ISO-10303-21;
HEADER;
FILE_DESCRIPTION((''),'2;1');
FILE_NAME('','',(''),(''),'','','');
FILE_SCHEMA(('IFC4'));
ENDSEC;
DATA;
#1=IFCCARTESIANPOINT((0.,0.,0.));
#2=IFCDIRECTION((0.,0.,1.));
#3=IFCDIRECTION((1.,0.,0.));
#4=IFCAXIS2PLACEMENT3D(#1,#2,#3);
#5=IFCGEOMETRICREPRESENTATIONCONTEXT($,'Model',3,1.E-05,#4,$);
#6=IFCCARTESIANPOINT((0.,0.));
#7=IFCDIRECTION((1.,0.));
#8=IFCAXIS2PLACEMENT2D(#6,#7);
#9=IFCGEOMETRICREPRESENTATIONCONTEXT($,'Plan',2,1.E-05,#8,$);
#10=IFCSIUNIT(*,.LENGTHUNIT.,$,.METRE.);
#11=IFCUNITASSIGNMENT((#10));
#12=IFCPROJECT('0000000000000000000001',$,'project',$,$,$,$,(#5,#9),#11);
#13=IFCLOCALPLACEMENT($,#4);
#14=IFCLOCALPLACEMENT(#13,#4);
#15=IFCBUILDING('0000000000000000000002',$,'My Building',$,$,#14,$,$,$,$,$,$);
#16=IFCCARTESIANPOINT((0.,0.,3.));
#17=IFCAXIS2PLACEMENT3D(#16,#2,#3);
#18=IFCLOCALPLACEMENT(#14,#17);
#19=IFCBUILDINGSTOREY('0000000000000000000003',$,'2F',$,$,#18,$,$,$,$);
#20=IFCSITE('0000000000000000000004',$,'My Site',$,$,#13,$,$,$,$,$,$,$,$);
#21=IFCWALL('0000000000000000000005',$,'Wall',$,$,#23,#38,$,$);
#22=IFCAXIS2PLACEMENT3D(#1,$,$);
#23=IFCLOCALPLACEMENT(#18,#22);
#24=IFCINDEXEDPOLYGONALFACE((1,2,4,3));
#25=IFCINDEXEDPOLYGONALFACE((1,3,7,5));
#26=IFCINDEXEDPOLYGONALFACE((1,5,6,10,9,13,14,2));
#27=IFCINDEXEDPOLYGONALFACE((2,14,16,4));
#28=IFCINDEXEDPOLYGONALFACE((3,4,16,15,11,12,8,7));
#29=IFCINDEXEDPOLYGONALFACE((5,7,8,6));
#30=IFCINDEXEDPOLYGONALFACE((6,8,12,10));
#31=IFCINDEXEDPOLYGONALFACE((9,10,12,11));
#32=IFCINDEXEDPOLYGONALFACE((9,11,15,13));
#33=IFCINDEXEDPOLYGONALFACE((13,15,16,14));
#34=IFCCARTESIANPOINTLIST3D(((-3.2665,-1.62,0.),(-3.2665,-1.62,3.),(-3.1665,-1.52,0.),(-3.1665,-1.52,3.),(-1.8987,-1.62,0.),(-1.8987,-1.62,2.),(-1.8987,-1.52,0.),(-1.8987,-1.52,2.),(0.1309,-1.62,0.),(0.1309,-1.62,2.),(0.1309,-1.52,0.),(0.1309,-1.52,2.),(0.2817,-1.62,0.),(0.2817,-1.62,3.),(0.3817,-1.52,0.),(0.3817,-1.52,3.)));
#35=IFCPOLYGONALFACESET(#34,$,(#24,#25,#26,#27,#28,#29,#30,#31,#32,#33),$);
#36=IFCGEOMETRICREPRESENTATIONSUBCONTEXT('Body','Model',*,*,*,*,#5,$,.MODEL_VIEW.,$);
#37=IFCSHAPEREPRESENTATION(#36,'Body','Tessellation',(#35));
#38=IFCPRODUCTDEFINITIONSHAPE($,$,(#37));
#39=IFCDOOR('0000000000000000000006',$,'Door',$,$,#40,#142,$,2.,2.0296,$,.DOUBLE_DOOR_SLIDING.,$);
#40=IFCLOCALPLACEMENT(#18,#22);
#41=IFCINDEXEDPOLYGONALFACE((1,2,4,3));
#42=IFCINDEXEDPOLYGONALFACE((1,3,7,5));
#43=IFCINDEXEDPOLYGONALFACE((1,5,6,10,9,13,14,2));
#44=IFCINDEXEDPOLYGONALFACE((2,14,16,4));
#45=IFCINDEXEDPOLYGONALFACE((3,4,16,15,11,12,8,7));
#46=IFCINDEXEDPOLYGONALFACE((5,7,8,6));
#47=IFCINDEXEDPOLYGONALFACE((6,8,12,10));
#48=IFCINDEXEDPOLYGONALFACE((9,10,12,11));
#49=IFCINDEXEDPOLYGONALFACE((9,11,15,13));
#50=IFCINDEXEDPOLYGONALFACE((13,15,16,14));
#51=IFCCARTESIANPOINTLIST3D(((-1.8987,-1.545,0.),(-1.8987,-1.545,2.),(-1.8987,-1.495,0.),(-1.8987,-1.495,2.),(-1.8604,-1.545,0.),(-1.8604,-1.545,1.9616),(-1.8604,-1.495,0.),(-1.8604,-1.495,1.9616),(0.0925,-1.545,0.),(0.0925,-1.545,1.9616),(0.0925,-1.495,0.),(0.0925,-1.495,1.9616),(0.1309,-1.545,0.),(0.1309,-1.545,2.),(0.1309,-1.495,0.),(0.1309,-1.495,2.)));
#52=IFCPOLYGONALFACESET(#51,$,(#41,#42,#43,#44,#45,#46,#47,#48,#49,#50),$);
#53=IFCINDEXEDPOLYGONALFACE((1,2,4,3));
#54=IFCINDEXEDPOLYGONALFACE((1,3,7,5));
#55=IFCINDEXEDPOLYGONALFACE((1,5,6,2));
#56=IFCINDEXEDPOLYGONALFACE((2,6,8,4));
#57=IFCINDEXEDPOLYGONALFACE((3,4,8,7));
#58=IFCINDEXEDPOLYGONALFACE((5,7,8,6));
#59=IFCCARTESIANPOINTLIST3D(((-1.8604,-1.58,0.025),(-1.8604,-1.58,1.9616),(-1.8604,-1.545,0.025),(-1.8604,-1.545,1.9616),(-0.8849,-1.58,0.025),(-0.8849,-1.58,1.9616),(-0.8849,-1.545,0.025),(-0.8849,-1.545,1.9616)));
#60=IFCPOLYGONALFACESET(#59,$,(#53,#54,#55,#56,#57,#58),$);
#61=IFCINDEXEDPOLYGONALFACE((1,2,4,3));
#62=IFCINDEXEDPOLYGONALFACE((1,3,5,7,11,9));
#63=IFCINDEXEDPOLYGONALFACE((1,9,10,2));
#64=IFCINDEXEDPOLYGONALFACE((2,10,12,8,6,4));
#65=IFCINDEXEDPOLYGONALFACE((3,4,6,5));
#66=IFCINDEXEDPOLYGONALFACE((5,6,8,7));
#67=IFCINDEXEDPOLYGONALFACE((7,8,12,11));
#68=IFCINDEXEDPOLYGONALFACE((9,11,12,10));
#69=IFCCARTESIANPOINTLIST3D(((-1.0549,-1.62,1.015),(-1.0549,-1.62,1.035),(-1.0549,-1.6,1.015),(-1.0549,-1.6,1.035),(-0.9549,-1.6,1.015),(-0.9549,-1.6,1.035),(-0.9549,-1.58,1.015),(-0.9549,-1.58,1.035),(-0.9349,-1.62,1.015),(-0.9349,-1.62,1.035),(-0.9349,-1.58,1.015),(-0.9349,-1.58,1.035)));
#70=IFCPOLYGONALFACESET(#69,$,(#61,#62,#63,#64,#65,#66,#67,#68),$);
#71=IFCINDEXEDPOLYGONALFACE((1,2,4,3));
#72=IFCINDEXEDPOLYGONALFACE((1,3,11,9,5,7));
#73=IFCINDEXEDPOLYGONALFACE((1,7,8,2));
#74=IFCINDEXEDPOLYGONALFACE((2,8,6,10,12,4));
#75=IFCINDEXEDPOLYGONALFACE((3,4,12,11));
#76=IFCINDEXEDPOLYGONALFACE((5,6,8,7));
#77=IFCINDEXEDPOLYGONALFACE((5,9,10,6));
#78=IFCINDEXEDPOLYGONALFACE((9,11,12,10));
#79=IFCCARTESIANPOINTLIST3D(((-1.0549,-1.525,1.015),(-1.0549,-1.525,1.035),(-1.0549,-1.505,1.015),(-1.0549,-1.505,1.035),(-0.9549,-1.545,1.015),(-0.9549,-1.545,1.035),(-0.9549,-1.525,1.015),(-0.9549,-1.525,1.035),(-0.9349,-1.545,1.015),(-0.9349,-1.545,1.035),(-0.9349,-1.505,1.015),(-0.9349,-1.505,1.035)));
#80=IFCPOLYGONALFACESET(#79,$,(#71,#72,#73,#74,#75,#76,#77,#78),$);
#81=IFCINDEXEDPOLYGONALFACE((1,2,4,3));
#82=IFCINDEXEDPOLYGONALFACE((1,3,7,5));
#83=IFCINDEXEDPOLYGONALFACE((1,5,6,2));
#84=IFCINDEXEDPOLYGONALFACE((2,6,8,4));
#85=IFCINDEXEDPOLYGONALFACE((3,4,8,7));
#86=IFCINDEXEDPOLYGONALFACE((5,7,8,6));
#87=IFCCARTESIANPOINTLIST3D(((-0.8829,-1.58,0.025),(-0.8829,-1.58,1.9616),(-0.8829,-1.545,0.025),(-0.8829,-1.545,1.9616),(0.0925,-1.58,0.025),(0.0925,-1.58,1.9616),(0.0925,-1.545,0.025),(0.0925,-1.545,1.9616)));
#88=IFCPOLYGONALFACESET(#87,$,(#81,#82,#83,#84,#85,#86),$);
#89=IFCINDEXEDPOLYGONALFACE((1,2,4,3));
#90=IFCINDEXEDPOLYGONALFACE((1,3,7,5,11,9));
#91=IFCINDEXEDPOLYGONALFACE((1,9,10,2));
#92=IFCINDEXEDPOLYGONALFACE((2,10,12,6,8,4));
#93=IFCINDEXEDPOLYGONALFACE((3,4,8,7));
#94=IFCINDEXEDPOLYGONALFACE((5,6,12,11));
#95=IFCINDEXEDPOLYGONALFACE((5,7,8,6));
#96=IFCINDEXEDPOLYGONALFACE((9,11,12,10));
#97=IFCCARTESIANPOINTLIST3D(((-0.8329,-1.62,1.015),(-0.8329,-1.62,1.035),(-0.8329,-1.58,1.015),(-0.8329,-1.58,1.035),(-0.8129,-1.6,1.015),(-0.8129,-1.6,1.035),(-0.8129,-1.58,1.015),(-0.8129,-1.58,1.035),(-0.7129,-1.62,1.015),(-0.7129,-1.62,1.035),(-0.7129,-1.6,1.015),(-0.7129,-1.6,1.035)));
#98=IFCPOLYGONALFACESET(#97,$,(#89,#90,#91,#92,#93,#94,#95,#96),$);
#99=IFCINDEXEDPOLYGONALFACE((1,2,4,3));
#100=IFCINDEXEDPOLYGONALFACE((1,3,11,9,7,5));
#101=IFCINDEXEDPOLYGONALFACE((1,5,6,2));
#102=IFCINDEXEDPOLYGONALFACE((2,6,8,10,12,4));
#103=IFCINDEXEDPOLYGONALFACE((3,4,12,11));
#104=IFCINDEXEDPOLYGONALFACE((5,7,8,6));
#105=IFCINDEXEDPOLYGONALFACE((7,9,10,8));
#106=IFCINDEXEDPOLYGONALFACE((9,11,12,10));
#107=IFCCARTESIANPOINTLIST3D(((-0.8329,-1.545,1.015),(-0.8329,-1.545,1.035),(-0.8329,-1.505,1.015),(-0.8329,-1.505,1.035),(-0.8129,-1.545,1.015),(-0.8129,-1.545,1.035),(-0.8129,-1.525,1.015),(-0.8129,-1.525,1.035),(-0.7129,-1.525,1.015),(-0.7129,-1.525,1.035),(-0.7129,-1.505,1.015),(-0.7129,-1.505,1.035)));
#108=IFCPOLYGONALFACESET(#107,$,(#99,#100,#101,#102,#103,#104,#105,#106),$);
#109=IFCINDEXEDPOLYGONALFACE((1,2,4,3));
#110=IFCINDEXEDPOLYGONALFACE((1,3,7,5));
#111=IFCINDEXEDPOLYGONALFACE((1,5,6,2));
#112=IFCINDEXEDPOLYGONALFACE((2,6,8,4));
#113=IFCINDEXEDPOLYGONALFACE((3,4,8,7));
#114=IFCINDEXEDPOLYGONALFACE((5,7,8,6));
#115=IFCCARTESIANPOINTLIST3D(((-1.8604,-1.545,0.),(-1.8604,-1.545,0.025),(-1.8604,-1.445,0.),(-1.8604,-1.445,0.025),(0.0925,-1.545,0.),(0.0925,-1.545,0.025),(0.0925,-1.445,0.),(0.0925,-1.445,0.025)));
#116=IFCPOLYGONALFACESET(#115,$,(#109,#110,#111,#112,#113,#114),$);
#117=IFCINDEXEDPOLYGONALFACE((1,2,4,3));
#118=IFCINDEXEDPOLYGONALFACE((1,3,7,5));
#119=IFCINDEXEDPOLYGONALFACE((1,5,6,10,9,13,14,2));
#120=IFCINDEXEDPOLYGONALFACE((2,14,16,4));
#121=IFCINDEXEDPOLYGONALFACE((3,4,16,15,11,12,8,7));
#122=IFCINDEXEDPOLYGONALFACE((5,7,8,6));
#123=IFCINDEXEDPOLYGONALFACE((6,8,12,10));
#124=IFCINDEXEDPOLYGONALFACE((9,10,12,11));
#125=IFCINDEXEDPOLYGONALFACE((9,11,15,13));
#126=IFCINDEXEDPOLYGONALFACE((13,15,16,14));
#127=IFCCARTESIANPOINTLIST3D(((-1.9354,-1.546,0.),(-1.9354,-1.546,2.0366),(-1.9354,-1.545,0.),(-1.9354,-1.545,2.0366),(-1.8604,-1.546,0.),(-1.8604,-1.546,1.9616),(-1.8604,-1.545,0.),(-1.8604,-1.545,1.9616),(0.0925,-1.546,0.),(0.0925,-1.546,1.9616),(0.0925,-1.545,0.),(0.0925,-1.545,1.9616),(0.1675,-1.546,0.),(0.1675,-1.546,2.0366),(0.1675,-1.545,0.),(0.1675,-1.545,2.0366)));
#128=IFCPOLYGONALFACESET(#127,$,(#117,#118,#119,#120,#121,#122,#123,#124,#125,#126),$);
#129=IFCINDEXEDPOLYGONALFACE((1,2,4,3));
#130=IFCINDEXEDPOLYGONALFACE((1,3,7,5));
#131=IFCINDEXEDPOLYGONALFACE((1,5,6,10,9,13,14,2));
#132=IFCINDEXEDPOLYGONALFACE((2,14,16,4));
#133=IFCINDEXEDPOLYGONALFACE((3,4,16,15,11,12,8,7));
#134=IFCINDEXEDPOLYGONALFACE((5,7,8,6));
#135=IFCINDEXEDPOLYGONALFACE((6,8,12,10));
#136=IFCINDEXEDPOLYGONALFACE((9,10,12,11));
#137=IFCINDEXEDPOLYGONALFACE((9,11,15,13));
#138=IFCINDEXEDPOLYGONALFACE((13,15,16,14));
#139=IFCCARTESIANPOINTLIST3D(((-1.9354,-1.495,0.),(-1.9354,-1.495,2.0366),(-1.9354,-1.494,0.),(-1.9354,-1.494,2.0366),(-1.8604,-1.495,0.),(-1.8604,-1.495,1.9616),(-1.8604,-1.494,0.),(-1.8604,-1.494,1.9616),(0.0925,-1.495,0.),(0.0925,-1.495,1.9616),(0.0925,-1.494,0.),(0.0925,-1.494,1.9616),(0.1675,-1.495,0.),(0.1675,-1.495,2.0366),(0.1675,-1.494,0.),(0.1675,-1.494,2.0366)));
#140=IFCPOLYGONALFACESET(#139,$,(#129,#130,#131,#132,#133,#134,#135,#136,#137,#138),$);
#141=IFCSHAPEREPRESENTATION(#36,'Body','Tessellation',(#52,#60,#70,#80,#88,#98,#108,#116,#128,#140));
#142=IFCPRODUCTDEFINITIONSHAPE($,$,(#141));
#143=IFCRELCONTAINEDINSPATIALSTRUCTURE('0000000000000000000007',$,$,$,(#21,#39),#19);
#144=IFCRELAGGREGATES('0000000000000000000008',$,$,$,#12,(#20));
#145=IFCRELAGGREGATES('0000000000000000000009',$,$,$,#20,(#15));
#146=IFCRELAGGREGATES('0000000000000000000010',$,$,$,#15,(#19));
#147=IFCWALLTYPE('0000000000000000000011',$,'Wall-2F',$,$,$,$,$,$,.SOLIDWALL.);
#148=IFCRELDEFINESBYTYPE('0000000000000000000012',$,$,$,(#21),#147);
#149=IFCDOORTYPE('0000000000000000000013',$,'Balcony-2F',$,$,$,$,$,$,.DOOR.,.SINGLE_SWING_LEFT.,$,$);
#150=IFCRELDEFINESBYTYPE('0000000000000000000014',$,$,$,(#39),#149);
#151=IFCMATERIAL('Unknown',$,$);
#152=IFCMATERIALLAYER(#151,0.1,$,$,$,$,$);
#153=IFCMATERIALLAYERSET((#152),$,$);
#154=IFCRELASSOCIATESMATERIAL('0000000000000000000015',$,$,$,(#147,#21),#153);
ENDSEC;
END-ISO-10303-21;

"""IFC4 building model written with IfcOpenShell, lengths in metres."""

from ifc_helpers import new_model, entity, si_unit, frame, origin_with_axes, origin_2d_with_axis, place, context, subcontext, project, spatial, line, indexed_curve, outline, extrude, shape, source, transform, mapped, material, layer, layer_set, layer_usage, type_object, type_shapes, element, fill, save


model = new_model("IFC4")

# Units and contexts
model_context = context("Model", 3, precision=1e-05, world=origin_with_axes())
plan_context = context("Plan", 2, precision=1e-05, world=origin_2d_with_axis())
body_context_1 = subcontext(model_context, "Body", "Model", "MODEL_VIEW")
body_context_2 = subcontext(plan_context, "Body", "Plan", "PLAN_VIEW")
ifc_project = project(units=[si_unit("LENGTHUNIT", "METRE")], contexts=[model_context, plan_context])

# Site, building, storey
site_placement = place(None, origin_with_axes())
site = spatial("IfcSite", under=ifc_project, at=site_placement, Name="My Site")
building_placement = place(site_placement, origin_with_axes())
building = spatial("IfcBuilding", under=site, at=building_placement, Name="My Building")
storey_placement = place(building_placement, frame((0.0, 0.0, 3.0), z_axis=(0.0, 0.0, 1.0), x_axis=(1.0, 0.0, 0.0)))
storey = spatial("IfcBuildingStorey", under=building, at=storey_placement, Name="2F")

# Shared definitions
ifc_material = material(Name="Unknown")

# Shared definitions
ifc_layer_1 = layer(ifc_material, 0.1)
ifc_layer_set_1 = layer_set([ifc_layer_1])
wall_type_1 = type_object("IfcWallType", Name="Wall-2F", PredefinedType="SOLIDWALL", material=ifc_layer_set_1)

# Wall, opening, door
ifc_layer_usage_1 = layer_usage(ifc_layer_set_1, "AXIS2", "POSITIVE", 0.0)
wall_1_placement = place(storey_placement, frame((-3.2665, -1.62, 0.0), z_axis=(0.0, 0.0, 1.0), x_axis=(1.0, 0.0, 0.0)))
wall_1 = element("IfcWall", 1, at=wall_1_placement, inside=storey, type_object=wall_type_1, material=ifc_layer_usage_1, Name="Wall", context=body_context_1, shape_type="SweptSolid", body=[
    extrude(outline(indexed_curve([(0.0, 0.0), (0.1, 0.1), (3.6482, 0.1), (3.5482, 0.0)], segments=[line(1, 2, 3, 4, 1)])), origin_with_axes(), (0.0, 0.0, 1.0), 3.0),
])
shared_shape_1 = source(origin_with_axes(), body_context_1, "Body", "SweptSolid", [
    extrude(outline(indexed_curve([(0.0, 0.0), (2.0296, 0.0), (2.0296, 2.0), (0.0, 2.0)], segments=[line(1, 2, 3, 4, 1)])), frame((0.0, -0.6, 0.0), z_axis=(0.0, -1.0, 0.0), x_axis=(1.0, 0.0, 0.0)), (0.0, 0.0, -1.0), 1.2),
])
opening_1_placement = place(wall_1_placement, frame((1.3677, 0.075, 0.0), z_axis=(0.0, 0.0, 1.0), x_axis=(1.0, 0.0, 0.0)))
opening_1 = element("IfcOpeningElement", 2, at=opening_1_placement, cuts=wall_1, PredefinedType="OPENING", context=body_context_1, shape_type="MappedRepresentation", body=[
    mapped(shared_shape_1, transform((0.0, 0.0, 0.0), x_axis=(1.0, 0.0, 0.0), y_axis=(0.0, 1.0, 0.0), z_axis=(0.0, 0.0, 1.0), scale=1.0)),
])
door_type_1 = type_object("IfcDoorType", Name="Balcony-2F", OperationType="SINGLE_SWING_LEFT", PredefinedType="DOOR")
shared_shape_2 = source(origin_with_axes(), body_context_1, "Body", "SweptSolid", [
    extrude(outline(indexed_curve([(0.0, 0.0), (0.0, 2.0), (2.0296, 2.0), (2.0296, 0.0), (1.9912, 0.0), (1.9912, 1.9616), (0.0384, 1.9616), (0.0384, 0.0)], segments=[line(1, 2, 3, 4, 5, 6, 7, 8, 1)])), frame((0.0, 0.0, 0.0), z_axis=(0.0, -1.0, 0.0), x_axis=(1.0, 0.0, 0.0)), (0.0, 0.0, -1.0), 0.05),
    extrude(outline(indexed_curve([(0.0, 0.0), (0.9754, 0.0), (0.9754, 0.035), (0.0, 0.035)], segments=[line(1, 2, 3, 4, 1)])), frame((0.0384, -0.035, 0.025), z_axis=(0.0, 0.0, 1.0), x_axis=(1.0, 0.0, 0.0)), (0.0, 0.0, 1.0), 1.9366),
    extrude(outline(indexed_curve([(0.0, 0.0), (0.0, -0.04), (-0.12, -0.04), (-0.12, -0.02), (-0.02, -0.02), (-0.02, 0.0)], segments=[line(1, 2, 3, 4, 5, 6, 1)])), frame((0.9638, -0.035, 1.015), z_axis=(0.0, 0.0, 1.0), x_axis=(1.0, 0.0, 0.0)), (0.0, 0.0, 1.0), 0.02),
    extrude(outline(indexed_curve([(0.0, 0.0), (0.0, 0.04), (-0.12, 0.04), (-0.12, 0.02), (-0.02, 0.02), (-0.02, 0.0)], segments=[line(1, 2, 3, 4, 5, 6, 1)])), frame((0.9638, 0.0, 1.015), z_axis=(0.0, 0.0, 1.0), x_axis=(1.0, 0.0, 0.0)), (0.0, 0.0, 1.0), 0.02),
    extrude(outline(indexed_curve([(0.0, 0.0), (-0.9754, 0.0), (-0.9754, 0.035), (0.0, 0.035)], segments=[line(1, 2, 3, 4, 1)])), frame((1.9912, -0.035, 0.025), z_axis=(0.0, 0.0, 1.0), x_axis=(1.0, 0.0, 0.0)), (0.0, 0.0, 1.0), 1.9366),
    extrude(outline(indexed_curve([(0.0, 0.0), (0.0, -0.04), (0.12, -0.04), (0.12, -0.02), (0.02, -0.02), (0.02, 0.0)], segments=[line(1, 2, 3, 4, 5, 6, 1)])), frame((1.0658, -0.035, 1.015), z_axis=(0.0, 0.0, 1.0), x_axis=(1.0, 0.0, 0.0)), (0.0, 0.0, 1.0), 0.02),
    extrude(outline(indexed_curve([(0.0, 0.0), (0.0, 0.04), (0.12, 0.04), (0.12, 0.02), (0.02, 0.02), (0.02, 0.0)], segments=[line(1, 2, 3, 4, 5, 6, 1)])), frame((1.0658, 0.0, 1.015), z_axis=(0.0, 0.0, 1.0), x_axis=(1.0, 0.0, 0.0)), (0.0, 0.0, 1.0), 0.02),
    extrude(outline(indexed_curve([(0.0, 0.0), (1.9529, 0.0), (1.9529, 0.1), (0.0, 0.1)], segments=[line(1, 2, 3, 4, 1)])), frame((0.0384, 0.0, 0.0), z_axis=(0.0, 0.0, 1.0), x_axis=(1.0, 0.0, 0.0)), (0.0, 0.0, 1.0), 0.025),
    extrude(outline(indexed_curve([(0.0, 0.0), (0.0, 2.0366), (2.1029, 2.0366), (2.1029, 0.0), (2.0279, 0.0), (2.0279, 1.9616), (0.075, 1.9616), (0.075, 0.0)], segments=[line(1, 2, 3, 4, 5, 6, 7, 8, 1)])), frame((-0.0366, -0.001, 0.0), z_axis=(0.0, -1.0, 0.0), x_axis=(1.0, 0.0, 0.0)), (0.0, 0.0, -1.0), 0.001),
    extrude(outline(indexed_curve([(0.0, 0.0), (0.0, 2.0366), (2.1029, 2.0366), (2.1029, 0.0), (2.0279, 0.0), (2.0279, 1.9616), (0.075, 1.9616), (0.075, 0.0)], segments=[line(1, 2, 3, 4, 5, 6, 7, 8, 1)])), frame((-0.0366, 0.05, 0.0), z_axis=(0.0, -1.0, 0.0), x_axis=(1.0, 0.0, 0.0)), (0.0, 0.0, -1.0), 0.001),
])
shared_shape_3 = source(origin_with_axes(), body_context_2, "Body", "Curve2D", [
    entity("IfcIndexedPolyCurve", entity("IfcCartesianPointList2D", [[0.0, 0.0], [0.0384, 0.0], [0.0384, 0.05], [0.0, 0.05]]), [entity("IfcLineIndex", [1, 2, 3, 4, 1])]),
    entity("IfcIndexedPolyCurve", entity("IfcCartesianPointList2D", [[2.0296, 0.0], [1.9912, 0.0], [1.9912, 0.05], [2.0296, 0.05]]), [entity("IfcLineIndex", [1, 2, 3, 4, 1])]),
    entity("IfcIndexedPolyCurve", entity("IfcCartesianPointList2D", [[-0.4498, -0.035], [0.5266, -0.035], [0.5266, 0.0], [-0.4498, 0.0]]), [entity("IfcLineIndex", [1, 2, 3, 4, 1])]),
    entity("IfcIndexedPolyCurve", entity("IfcCartesianPointList2D", [[2.4794, -0.035], [1.503, -0.035], [1.503, 0.0], [2.4794, 0.0]]), [entity("IfcLineIndex", [1, 2, 3, 4, 1])]),
])
type_shapes(door_type_1, [shared_shape_2, shared_shape_3])
door_1_placement = place(opening_1_placement, frame((0.0, 0.0, 0.0), z_axis=(0.0, 0.0, 1.0), x_axis=(1.0, 0.0, 0.0)))
door_1 = element("IfcDoor", 3, at=door_1_placement, inside=storey, type_object=door_type_1, Name="Door", OperationType="DOUBLE_DOOR_SLIDING", OverallHeight=2.0, OverallWidth=2.0296, shapes=[
    shape(body_context_1, "Body", "MappedRepresentation", [mapped(shared_shape_2, transform((0.0, 0.0, 0.0), x_axis=(1.0, 0.0, 0.0), y_axis=(0.0, 1.0, 0.0), z_axis=(0.0, 0.0, 1.0), scale=1.0))]),
    shape(body_context_2, "Body", "MappedRepresentation", [mapped(shared_shape_3, transform((0.0, 0.0, 0.0), x_axis=(1.0, 0.0, 0.0), y_axis=(0.0, 1.0, 0.0), z_axis=(0.0, 0.0, 1.0), scale=1.0))]),
])
fill(opening_1, door_1)

save(model, "model.ifc")
